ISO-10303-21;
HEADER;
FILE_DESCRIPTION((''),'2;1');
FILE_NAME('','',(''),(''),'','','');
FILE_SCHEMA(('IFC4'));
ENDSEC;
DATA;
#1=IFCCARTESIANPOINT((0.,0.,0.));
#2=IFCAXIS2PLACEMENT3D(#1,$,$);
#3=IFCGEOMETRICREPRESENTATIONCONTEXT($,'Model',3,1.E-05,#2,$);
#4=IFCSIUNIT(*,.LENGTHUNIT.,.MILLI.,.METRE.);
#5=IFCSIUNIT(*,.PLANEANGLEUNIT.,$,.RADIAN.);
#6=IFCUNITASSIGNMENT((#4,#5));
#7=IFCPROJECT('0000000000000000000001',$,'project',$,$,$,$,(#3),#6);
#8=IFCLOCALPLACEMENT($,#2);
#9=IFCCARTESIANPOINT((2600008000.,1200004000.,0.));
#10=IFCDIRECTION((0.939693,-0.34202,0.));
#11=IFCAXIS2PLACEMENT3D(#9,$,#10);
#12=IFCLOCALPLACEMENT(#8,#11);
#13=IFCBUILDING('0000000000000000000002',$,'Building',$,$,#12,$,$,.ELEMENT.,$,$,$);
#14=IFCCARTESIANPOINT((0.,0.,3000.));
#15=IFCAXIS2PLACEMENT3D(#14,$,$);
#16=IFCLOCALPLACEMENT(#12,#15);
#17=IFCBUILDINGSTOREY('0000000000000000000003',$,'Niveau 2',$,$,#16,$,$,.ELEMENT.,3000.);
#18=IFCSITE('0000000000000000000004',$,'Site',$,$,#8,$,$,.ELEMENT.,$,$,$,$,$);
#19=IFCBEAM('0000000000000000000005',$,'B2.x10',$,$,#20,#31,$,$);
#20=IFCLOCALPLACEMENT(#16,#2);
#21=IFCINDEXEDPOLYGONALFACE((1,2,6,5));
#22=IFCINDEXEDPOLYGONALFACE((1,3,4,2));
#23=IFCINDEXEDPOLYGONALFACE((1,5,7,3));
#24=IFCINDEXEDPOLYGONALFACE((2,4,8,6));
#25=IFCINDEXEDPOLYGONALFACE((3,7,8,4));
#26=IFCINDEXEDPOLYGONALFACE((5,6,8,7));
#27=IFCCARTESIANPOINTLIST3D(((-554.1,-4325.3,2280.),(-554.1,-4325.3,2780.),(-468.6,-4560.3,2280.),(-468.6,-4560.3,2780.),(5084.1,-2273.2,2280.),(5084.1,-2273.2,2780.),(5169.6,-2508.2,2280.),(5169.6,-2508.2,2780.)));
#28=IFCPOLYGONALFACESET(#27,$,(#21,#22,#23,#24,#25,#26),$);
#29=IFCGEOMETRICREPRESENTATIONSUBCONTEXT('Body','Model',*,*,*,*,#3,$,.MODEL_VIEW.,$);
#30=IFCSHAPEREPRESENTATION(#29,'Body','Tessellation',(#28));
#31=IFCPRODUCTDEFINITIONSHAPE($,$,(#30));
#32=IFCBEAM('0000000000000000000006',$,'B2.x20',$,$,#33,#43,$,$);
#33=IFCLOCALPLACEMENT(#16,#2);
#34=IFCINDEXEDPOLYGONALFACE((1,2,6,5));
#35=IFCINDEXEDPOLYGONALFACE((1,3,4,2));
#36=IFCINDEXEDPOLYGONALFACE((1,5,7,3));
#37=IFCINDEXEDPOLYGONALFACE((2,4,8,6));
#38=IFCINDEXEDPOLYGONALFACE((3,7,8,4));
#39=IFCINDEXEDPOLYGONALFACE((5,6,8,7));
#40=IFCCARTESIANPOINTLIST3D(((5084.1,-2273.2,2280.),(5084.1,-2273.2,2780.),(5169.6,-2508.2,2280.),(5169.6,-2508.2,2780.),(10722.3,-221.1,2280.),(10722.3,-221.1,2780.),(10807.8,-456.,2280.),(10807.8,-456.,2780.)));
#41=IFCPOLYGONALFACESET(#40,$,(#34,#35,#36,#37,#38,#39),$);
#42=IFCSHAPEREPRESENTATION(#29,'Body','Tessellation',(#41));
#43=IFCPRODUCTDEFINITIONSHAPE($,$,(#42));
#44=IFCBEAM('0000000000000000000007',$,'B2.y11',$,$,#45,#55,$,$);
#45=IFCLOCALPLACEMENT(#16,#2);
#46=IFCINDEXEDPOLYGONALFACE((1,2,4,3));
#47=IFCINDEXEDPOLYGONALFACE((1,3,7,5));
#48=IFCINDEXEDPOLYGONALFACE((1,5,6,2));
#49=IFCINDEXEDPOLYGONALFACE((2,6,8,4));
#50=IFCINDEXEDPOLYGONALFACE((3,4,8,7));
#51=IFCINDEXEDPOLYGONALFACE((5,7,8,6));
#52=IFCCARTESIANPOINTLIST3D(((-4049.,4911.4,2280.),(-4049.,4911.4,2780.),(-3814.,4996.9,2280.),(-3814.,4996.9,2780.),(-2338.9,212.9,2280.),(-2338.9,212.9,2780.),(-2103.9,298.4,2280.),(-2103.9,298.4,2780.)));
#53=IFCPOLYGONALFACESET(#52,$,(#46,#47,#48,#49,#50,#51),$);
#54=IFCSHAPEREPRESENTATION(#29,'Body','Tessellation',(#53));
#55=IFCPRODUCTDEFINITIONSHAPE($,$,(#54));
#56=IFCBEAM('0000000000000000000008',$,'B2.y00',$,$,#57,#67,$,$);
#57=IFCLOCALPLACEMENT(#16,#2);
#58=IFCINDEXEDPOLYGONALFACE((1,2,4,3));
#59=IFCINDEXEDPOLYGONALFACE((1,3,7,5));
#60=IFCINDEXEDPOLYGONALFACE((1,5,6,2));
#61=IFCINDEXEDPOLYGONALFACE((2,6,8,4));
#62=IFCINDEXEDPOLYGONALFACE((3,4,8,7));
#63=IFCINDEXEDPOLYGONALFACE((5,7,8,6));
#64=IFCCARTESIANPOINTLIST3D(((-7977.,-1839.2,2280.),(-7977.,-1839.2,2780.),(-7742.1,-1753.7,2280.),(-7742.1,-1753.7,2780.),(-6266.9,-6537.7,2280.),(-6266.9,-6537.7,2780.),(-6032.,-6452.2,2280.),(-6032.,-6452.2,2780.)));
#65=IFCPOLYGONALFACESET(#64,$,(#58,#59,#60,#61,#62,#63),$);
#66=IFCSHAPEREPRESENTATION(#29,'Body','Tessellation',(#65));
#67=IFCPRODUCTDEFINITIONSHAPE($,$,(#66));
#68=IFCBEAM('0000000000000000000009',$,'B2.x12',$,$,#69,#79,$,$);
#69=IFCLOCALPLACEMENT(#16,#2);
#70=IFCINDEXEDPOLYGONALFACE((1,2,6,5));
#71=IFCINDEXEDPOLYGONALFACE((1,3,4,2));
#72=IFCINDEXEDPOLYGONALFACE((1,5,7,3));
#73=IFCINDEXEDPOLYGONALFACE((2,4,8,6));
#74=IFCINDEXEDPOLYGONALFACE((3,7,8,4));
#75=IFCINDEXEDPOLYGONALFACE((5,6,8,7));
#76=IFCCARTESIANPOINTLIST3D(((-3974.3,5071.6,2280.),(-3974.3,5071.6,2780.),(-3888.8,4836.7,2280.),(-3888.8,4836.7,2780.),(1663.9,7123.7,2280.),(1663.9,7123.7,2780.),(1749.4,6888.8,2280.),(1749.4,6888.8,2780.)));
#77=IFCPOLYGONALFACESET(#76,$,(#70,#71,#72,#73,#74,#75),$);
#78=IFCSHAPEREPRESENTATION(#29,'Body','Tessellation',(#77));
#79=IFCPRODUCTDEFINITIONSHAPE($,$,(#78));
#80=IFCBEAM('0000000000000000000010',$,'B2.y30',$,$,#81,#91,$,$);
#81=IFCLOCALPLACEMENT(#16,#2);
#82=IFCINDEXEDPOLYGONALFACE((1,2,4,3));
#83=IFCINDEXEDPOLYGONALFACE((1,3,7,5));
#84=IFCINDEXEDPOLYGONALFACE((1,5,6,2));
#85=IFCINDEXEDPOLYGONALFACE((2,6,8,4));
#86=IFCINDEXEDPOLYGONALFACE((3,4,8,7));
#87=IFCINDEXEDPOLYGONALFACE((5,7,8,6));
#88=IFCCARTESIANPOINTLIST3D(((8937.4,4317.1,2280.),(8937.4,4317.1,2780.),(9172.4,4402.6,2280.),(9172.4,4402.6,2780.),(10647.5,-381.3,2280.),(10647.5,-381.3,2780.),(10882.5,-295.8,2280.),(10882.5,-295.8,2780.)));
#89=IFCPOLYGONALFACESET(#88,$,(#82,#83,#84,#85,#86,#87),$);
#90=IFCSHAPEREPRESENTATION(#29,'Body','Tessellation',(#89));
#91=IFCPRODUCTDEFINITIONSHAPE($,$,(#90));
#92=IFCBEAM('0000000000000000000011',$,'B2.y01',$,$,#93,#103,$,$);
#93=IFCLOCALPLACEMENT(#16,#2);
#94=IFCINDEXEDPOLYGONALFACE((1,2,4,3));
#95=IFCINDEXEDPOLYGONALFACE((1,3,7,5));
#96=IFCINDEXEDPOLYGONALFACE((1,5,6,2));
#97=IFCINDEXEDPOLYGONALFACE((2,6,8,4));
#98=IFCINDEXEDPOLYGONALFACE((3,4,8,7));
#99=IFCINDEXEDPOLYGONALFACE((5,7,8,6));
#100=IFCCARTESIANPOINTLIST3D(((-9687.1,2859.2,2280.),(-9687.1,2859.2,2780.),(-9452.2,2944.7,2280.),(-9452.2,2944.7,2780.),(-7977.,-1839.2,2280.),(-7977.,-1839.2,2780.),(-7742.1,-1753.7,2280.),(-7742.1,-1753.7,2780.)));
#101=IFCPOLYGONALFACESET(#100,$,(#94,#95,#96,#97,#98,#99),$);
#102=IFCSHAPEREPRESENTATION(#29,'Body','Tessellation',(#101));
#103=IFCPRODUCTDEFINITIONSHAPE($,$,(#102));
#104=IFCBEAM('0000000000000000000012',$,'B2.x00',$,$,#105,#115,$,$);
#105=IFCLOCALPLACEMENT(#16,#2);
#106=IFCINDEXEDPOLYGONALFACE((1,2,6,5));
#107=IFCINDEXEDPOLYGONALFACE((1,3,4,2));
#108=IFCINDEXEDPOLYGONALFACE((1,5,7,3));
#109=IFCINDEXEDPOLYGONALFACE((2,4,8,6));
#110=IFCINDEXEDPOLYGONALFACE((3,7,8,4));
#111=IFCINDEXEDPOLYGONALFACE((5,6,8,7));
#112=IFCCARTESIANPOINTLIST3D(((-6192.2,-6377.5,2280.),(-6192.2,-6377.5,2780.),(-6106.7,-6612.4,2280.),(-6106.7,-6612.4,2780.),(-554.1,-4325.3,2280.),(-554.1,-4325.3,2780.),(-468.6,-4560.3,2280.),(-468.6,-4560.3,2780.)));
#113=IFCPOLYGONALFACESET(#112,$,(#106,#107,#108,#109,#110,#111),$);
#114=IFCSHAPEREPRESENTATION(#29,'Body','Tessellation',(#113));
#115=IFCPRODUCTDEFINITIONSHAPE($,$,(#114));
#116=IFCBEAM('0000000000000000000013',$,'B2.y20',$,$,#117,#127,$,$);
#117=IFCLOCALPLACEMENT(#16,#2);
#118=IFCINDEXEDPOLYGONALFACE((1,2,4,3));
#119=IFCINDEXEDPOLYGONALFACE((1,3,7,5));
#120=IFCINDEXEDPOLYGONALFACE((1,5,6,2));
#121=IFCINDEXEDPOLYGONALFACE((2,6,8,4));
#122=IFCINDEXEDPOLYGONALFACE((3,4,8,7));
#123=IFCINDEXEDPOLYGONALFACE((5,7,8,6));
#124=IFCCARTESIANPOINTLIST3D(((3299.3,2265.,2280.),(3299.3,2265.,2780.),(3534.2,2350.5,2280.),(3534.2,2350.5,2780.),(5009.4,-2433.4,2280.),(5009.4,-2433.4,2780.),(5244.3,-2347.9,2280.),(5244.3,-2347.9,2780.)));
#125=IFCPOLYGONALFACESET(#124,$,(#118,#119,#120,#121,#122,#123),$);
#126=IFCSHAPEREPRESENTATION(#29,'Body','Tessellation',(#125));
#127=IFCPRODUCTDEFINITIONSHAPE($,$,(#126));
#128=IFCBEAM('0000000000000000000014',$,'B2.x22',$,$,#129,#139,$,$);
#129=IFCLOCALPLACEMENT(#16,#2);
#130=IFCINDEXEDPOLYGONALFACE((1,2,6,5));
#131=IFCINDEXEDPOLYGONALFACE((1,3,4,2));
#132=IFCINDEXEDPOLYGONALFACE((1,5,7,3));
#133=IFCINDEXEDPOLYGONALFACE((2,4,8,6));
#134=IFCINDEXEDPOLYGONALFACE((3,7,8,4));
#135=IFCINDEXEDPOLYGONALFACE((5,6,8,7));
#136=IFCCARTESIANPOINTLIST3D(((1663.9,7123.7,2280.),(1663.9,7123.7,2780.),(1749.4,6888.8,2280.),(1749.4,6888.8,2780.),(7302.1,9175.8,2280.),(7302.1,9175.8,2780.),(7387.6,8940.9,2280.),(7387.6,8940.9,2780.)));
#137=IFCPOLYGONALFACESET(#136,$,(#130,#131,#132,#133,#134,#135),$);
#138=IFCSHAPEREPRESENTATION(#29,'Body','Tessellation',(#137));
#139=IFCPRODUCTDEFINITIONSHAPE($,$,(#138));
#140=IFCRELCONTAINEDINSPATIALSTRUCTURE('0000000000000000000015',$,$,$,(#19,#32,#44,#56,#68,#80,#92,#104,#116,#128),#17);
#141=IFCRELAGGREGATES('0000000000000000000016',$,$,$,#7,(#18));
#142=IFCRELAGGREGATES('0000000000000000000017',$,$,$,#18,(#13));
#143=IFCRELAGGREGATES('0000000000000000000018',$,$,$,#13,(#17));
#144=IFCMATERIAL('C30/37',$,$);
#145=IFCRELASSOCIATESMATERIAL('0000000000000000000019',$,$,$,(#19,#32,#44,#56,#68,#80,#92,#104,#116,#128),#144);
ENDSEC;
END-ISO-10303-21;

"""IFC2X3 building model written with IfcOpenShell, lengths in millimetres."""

from ifc_helpers import new_model, si_unit, frame, origin, origin_2d, place, context, subcontext, project, spatial, rectangle, extrude, material, element, save


model = new_model("IFC2X3")

# Units and contexts
model_context = context("Model", 3, precision=1e-05, world=origin())
body_context = subcontext(model_context, "Body", "Model", "MODEL_VIEW")
ifc_project = project(units=[si_unit("LENGTHUNIT", "METRE", prefix="MILLI"), si_unit("PLANEANGLEUNIT", "RADIAN")], contexts=[model_context])

# Site, building, storey
site_placement = place(None, origin())
site = spatial("IfcSite", under=ifc_project, at=site_placement, Name="Site", CompositionType="ELEMENT")
building_placement = place(site_placement, frame((2600008000.0, 1200004000.0, 0.0), x_axis=(0.939693, -0.34202, 0.0)))
building = spatial("IfcBuilding", under=site, at=building_placement, Name="Building", CompositionType="ELEMENT")
storey_placement = place(building_placement, frame((0.0, 0.0, 3000.0)))
storey = spatial("IfcBuildingStorey", under=building, at=storey_placement, Name="Niveau 2", CompositionType="ELEMENT", Elevation=3000.0)

# Shared definitions
ifc_material = material(Name="C30/37")

# Beams
for number, where, z_axis, x_axis, name in (
    (1, (-511.3, -4442.8, 2530.0), (0.939693, 0.34202, 0.0), (-0.34202, 0.939693, 0.0), "B2.x10"),
    (2, (5126.9, -2390.7, 2530.0), (0.939693, 0.34202, 0.0), (-0.34202, 0.939693, 0.0), "B2.x20"),
):
    element("IfcBeam", number, at=place(storey_placement, frame(where, z_axis=z_axis, x_axis=x_axis)), inside=storey, material=ifc_material, Name=name, context=body_context, shape_type="SweptSolid", body=[
        extrude(rectangle(XDim=250.0, YDim=500.0, at=origin_2d()), origin(), (0.0, 0.0, 1.0), 6000.0),
    ])
for number, where, z_axis, x_axis, name in (
    (3, (-2221.4, 255.7, 2530.0), (-0.34202, 0.939693, 0.0), (-0.939693, -0.34202, 0.0), "B2.y11"),
    (4, (-6149.5, -6494.9, 2530.0), (-0.34202, 0.939693, 0.0), (-0.939693, -0.34202, 0.0), "B2.y00"),
):
    element("IfcBeam", number, at=place(storey_placement, frame(where, z_axis=z_axis, x_axis=x_axis)), inside=storey, material=ifc_material, Name=name, context=body_context, shape_type="SweptSolid", body=[
        extrude(rectangle(XDim=250.0, YDim=500.0, at=origin_2d()), origin(), (0.0, 0.0, 1.0), 5000.0),
    ])
beam_1_placement = place(storey_placement, frame((-3931.5, 4954.1, 2530.0), z_axis=(0.939693, 0.34202, 0.0), x_axis=(-0.34202, 0.939693, 0.0)))
element("IfcBeam", 5, at=beam_1_placement, inside=storey, material=ifc_material, Name="B2.x12", context=body_context, shape_type="SweptSolid", body=[
    extrude(rectangle(XDim=250.0, YDim=500.0, at=origin_2d()), origin(), (0.0, 0.0, 1.0), 6000.0),
])
for number, where, z_axis, x_axis, name in (
    (6, (10765.0, -338.6, 2530.0), (-0.34202, 0.939693, 0.0), (-0.939693, -0.34202, 0.0), "B2.y30"),
    (7, (-7859.6, -1796.5, 2530.0), (-0.34202, 0.939693, 0.0), (-0.939693, -0.34202, 0.0), "B2.y01"),
):
    element("IfcBeam", number, at=place(storey_placement, frame(where, z_axis=z_axis, x_axis=x_axis)), inside=storey, material=ifc_material, Name=name, context=body_context, shape_type="SweptSolid", body=[
        extrude(rectangle(XDim=250.0, YDim=500.0, at=origin_2d()), origin(), (0.0, 0.0, 1.0), 5000.0),
    ])
beam_2_placement = place(storey_placement, frame((-6149.5, -6494.9, 2530.0), z_axis=(0.939693, 0.34202, 0.0), x_axis=(-0.34202, 0.939693, 0.0)))
element("IfcBeam", 8, at=beam_2_placement, inside=storey, material=ifc_material, Name="B2.x00", context=body_context, shape_type="SweptSolid", body=[
    extrude(rectangle(XDim=250.0, YDim=500.0, at=origin_2d()), origin(), (0.0, 0.0, 1.0), 6000.0),
])
beam_3_placement = place(storey_placement, frame((5126.9, -2390.7, 2530.0), z_axis=(-0.34202, 0.939693, 0.0), x_axis=(-0.939693, -0.34202, 0.0)))
element("IfcBeam", 9, at=beam_3_placement, inside=storey, material=ifc_material, Name="B2.y20", context=body_context, shape_type="SweptSolid", body=[
    extrude(rectangle(XDim=250.0, YDim=500.0, at=origin_2d()), origin(), (0.0, 0.0, 1.0), 5000.0),
])
beam_4_placement = place(storey_placement, frame((1706.6, 7006.2, 2530.0), z_axis=(0.939693, 0.34202, 0.0), x_axis=(-0.34202, 0.939693, 0.0)))
element("IfcBeam", 10, at=beam_4_placement, inside=storey, material=ifc_material, Name="B2.x22", context=body_context, shape_type="SweptSolid", body=[
    extrude(rectangle(XDim=250.0, YDim=500.0, at=origin_2d()), origin(), (0.0, 0.0, 1.0), 6000.0),
])

save(model, "model.ifc")
